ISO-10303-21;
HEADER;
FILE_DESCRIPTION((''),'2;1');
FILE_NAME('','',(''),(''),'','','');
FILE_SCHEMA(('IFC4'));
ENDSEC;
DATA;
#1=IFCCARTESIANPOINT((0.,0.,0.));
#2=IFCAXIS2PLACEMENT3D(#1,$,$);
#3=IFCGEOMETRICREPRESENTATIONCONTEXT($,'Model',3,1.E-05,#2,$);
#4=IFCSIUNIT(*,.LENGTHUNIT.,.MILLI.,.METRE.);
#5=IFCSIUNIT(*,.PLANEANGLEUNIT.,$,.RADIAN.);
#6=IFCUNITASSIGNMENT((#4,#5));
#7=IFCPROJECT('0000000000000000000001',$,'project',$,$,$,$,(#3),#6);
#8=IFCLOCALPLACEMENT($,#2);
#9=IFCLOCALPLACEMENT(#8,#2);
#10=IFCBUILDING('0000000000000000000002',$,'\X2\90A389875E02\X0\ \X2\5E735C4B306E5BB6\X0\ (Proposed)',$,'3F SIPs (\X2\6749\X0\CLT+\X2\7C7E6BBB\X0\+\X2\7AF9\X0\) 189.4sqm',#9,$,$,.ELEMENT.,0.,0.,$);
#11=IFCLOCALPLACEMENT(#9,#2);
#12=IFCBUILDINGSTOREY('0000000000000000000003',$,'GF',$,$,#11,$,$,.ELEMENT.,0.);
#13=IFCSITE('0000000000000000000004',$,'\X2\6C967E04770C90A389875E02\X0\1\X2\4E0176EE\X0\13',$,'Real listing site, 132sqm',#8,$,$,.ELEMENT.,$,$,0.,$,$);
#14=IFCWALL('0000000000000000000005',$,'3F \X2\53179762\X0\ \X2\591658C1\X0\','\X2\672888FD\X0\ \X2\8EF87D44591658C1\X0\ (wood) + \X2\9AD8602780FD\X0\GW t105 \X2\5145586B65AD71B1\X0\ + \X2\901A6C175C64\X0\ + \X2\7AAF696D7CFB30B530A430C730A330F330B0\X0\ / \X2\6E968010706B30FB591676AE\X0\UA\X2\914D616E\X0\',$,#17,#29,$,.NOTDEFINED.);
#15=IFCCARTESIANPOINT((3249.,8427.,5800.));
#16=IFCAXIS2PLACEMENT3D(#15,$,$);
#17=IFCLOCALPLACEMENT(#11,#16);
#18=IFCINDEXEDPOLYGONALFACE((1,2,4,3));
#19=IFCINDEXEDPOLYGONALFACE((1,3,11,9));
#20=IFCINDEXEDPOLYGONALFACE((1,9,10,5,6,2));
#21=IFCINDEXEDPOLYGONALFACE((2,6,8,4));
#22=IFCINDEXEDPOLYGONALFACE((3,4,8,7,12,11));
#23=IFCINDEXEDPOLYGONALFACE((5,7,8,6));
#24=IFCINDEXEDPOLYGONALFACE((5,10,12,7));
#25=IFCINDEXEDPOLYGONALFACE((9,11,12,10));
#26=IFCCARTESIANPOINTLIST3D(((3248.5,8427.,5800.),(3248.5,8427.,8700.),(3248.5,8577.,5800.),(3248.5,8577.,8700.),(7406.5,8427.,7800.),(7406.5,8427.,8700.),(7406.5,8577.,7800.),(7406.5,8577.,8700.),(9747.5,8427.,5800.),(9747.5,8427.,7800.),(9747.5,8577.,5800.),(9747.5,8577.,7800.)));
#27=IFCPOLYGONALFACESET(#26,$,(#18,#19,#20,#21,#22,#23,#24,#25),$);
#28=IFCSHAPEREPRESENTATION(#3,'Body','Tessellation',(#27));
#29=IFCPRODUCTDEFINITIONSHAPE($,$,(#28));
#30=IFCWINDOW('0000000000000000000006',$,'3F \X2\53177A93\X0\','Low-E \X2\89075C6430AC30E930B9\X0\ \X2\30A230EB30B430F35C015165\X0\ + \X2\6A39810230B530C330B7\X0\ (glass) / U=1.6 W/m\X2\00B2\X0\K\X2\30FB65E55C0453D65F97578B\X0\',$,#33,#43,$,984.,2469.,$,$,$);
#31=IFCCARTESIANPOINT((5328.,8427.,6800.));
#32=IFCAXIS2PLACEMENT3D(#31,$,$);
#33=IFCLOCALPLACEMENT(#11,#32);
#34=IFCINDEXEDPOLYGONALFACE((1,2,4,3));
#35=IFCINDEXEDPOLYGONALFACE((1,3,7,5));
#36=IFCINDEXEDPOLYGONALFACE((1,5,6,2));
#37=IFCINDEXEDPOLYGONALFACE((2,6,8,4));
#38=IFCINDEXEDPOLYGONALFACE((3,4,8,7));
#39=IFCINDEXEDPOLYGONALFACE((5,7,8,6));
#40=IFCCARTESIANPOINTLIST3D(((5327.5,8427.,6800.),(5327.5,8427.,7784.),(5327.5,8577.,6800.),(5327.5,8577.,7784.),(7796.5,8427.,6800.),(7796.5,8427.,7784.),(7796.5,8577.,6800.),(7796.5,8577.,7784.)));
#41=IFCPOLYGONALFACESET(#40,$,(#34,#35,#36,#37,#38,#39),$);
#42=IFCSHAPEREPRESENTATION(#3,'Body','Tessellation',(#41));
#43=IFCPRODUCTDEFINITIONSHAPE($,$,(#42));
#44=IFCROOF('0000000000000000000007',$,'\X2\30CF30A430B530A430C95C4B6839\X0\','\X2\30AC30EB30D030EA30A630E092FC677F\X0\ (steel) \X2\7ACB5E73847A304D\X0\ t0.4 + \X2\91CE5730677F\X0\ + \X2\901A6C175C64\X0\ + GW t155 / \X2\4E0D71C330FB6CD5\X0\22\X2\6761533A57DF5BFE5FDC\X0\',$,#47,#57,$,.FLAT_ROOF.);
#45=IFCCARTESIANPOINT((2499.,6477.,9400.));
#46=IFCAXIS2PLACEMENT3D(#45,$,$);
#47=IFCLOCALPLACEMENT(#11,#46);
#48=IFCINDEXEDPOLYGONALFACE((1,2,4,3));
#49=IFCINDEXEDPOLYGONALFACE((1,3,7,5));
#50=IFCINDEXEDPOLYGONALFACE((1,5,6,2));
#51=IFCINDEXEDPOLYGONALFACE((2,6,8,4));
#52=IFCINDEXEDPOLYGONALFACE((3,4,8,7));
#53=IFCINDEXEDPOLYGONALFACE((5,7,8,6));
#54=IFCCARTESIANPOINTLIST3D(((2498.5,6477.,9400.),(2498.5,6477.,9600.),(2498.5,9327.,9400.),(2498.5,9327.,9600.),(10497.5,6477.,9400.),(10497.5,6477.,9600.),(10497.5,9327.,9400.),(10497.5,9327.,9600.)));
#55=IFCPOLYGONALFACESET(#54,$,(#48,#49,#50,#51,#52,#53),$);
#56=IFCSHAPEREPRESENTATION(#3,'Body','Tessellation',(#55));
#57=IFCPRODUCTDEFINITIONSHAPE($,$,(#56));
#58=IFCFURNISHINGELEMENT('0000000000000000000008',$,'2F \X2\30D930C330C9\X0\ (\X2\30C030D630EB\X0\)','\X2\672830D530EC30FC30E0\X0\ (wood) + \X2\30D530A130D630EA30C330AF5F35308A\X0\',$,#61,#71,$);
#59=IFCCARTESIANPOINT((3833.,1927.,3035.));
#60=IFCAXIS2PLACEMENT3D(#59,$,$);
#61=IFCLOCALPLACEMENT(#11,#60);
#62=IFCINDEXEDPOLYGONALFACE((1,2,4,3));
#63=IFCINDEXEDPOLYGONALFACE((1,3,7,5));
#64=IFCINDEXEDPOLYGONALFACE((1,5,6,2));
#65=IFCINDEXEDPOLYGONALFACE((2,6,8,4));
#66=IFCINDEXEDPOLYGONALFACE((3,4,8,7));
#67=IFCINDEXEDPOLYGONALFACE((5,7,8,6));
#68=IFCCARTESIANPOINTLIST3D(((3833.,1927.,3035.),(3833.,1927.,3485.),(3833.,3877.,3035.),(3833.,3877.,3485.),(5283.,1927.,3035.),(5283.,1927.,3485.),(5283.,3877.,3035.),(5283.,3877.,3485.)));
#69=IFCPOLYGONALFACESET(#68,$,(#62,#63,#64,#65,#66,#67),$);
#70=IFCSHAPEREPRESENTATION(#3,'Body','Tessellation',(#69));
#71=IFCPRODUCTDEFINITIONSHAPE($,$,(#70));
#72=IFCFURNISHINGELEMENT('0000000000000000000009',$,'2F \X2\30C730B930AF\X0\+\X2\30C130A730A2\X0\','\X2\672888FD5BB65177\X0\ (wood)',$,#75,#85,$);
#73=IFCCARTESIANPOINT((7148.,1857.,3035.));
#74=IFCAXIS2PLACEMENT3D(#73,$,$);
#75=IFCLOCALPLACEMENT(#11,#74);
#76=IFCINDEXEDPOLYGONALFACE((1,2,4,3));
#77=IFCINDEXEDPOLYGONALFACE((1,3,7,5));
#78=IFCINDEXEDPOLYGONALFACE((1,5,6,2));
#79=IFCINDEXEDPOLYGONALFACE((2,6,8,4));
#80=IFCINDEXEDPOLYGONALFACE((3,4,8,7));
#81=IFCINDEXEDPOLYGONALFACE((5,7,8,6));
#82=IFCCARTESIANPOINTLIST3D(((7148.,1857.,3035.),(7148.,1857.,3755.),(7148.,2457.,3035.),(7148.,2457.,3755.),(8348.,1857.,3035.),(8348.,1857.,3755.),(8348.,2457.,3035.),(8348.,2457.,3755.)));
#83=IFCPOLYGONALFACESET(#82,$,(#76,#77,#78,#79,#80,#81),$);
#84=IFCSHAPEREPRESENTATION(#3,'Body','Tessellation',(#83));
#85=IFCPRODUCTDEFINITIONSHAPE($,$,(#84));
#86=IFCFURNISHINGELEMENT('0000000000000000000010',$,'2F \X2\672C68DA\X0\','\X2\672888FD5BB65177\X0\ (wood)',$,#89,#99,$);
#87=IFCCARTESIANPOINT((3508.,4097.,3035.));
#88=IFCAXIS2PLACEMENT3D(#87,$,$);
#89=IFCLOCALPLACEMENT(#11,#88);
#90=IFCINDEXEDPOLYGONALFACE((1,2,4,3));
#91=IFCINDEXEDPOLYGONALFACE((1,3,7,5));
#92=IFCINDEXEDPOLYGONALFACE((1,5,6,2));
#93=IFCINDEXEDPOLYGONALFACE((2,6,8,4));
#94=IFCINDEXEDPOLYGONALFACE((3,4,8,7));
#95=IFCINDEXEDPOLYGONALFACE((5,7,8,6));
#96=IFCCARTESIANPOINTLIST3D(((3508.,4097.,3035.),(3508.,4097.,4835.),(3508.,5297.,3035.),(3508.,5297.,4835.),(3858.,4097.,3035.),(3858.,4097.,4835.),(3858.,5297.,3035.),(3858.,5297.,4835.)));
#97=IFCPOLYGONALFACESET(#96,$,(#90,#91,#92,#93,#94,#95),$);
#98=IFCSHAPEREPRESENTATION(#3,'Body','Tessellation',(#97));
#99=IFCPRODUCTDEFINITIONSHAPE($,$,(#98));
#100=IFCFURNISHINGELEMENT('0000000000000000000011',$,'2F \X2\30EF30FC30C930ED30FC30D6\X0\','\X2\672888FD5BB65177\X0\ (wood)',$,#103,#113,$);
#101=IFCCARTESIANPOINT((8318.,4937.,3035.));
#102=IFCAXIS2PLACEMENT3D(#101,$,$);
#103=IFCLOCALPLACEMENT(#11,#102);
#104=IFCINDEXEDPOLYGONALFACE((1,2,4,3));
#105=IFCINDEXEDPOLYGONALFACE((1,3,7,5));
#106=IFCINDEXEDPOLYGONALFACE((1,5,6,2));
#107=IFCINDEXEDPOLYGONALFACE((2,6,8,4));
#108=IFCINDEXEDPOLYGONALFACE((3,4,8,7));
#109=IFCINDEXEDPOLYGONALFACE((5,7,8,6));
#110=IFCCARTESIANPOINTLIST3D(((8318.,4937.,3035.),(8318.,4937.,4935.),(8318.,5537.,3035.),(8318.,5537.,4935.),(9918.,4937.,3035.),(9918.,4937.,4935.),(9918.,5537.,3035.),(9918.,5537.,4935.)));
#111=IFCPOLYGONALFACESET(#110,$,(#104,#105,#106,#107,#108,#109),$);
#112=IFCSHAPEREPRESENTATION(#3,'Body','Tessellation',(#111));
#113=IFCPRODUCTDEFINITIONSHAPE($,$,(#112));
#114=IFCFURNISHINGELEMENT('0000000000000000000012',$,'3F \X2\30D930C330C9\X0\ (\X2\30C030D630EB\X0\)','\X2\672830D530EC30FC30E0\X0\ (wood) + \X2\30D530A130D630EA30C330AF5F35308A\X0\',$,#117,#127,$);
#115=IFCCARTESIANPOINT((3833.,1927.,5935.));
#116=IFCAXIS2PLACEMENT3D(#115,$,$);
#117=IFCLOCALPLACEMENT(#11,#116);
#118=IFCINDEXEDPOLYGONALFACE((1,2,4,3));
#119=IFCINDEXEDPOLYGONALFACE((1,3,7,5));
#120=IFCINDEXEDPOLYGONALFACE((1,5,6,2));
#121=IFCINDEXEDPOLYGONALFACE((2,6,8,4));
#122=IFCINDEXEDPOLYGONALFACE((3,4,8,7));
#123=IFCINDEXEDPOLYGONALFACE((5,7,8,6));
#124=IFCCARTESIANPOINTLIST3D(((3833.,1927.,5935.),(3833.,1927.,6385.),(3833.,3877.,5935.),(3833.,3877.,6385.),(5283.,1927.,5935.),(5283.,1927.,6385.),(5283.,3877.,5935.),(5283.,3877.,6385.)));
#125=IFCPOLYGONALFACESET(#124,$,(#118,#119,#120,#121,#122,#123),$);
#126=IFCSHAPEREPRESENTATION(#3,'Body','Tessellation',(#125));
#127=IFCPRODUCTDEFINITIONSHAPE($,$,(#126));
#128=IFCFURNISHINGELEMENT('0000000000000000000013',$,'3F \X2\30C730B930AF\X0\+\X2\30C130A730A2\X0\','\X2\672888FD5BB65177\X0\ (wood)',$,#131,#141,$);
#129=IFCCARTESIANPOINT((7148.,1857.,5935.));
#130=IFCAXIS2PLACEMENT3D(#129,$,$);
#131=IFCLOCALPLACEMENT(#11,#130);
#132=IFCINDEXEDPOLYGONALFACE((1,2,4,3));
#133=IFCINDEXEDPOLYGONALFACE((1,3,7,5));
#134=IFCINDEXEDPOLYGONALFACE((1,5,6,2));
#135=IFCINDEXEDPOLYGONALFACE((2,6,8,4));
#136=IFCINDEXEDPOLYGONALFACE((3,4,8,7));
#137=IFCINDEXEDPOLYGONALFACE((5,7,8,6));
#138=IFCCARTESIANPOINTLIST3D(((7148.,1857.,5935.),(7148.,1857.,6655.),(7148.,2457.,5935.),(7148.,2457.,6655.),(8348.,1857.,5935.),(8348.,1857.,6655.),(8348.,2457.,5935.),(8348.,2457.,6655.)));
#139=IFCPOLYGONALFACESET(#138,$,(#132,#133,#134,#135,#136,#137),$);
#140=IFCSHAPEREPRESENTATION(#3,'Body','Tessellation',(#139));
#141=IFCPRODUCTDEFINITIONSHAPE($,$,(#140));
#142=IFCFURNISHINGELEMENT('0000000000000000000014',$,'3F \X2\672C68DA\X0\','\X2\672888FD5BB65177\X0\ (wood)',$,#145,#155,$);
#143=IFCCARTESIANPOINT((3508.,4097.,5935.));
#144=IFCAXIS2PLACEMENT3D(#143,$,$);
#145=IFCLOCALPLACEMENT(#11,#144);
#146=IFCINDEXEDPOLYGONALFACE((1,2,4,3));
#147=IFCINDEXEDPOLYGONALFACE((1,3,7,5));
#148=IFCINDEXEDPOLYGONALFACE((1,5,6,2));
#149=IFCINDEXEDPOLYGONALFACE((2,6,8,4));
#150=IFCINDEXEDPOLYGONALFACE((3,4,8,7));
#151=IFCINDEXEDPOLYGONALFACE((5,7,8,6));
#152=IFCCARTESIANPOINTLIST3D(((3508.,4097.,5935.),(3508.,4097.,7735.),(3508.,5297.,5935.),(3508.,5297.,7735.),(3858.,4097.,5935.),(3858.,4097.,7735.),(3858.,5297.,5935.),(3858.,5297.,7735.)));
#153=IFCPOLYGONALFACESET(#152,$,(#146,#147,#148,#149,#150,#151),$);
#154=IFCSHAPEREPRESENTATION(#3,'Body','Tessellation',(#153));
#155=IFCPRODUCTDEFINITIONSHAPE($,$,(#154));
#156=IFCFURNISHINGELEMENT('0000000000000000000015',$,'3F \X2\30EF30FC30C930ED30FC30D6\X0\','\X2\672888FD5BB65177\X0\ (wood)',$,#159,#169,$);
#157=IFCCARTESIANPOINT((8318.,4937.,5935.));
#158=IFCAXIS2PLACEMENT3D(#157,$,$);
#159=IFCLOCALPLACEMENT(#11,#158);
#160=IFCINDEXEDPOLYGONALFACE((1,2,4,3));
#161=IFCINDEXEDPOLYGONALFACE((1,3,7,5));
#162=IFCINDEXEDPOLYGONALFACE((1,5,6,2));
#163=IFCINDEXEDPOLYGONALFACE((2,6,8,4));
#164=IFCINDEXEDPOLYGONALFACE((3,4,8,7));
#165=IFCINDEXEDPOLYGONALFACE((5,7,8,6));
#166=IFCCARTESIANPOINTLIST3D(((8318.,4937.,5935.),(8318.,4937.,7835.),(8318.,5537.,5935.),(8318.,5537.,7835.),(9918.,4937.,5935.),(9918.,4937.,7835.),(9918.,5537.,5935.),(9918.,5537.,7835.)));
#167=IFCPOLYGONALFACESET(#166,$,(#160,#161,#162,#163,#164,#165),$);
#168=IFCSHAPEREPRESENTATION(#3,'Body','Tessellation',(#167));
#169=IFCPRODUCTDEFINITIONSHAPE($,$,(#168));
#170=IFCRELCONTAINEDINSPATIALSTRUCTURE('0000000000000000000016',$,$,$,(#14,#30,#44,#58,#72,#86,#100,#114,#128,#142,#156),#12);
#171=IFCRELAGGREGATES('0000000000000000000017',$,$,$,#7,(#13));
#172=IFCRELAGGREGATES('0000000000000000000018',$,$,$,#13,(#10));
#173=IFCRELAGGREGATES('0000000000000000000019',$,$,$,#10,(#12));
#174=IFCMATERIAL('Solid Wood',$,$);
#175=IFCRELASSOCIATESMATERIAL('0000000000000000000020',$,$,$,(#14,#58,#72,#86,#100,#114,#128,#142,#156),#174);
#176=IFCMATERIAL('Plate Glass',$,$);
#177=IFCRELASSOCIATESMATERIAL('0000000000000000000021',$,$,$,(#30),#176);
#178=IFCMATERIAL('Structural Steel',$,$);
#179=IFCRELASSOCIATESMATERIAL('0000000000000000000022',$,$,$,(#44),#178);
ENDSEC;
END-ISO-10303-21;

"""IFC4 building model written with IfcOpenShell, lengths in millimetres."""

from ifc_helpers import new_model, si_unit, frame, frame_2d, origin, place, context, project, spatial, rectangle, extrude, material, element, fill, save


model = new_model("IFC4")

# Units and contexts
model_context = context("Model", 3, precision=1e-05, world=origin())
ifc_project = project(units=[si_unit("LENGTHUNIT", "METRE", prefix="MILLI"), si_unit("PLANEANGLEUNIT", "RADIAN")], contexts=[model_context])

# Site, building, storey
site_placement = place(None, origin())
site = spatial("IfcSite", under=ifc_project, at=site_placement, Name="沖縄県那覇市1丁目13", ObjectType="Real listing site, 132sqm", CompositionType="ELEMENT", RefElevation=0.0)
building_placement = place(site_placement, origin())
building = spatial("IfcBuilding", under=site, at=building_placement, Name="那覇市 平屋の家 (Proposed)", ObjectType="3F SIPs (杉CLT+籾殻+竹) 189.4sqm", CompositionType="ELEMENT", ElevationOfRefHeight=0.0, ElevationOfTerrain=0.0)
storey_placement = place(building_placement, origin())
storey = spatial("IfcBuildingStorey", under=building, at=storey_placement, Name="GF", CompositionType="ELEMENT", Elevation=0.0)

# Shared definitions
ifc_material_1 = material(Name="Solid Wood")

# Wall, opening, window
wall_1_placement = place(storey_placement, frame((3249.0, 8427.0, 5800.0)))
wall_1 = element("IfcWall", 1, at=wall_1_placement, inside=storey, material=ifc_material_1, Name="3F 北面 外壁", Description="木製 軸組外壁 (wood) + 高性能GW t105 充填断熱 + 通気層 + 窯業系サイディング / 準耐火・外皮UA配慮", PredefinedType="NOTDEFINED", context=model_context, shape_type="SweptSolid", body=[
    extrude(rectangle(XDim=6499.0, YDim=150.0, at=frame_2d((3249.0, 75.0))), frame((3249.0, 8427.0, 5800.0)), (0.0, 0.0, 1.0), 2900.0),
])
opening_1_placement = place(storey_placement, frame((5328.0, 8427.0, 6800.0)))
opening_1 = element("IfcOpeningElement", 2, at=opening_1_placement, cuts=wall_1, PredefinedType="NOTDEFINED", context=model_context, shape_type="SweptSolid", body=[
    extrude(rectangle(XDim=2469.0, YDim=150.0, at=frame_2d((1234.0, 75.0))), frame((5328.0, 8427.0, 6800.0)), (0.0, 0.0, 1.0), 984.0),
])
ifc_material_2 = material(Name="Plate Glass")
window_1_placement = place(storey_placement, frame((5328.0, 8427.0, 6800.0)))
window_1 = element("IfcWindow", 3, at=window_1_placement, inside=storey, material=ifc_material_2, Name="3F 北窓", Description="Low-E 複層ガラス アルゴン封入 + 樹脂サッシ (glass) / U=1.6 W/m²K・日射取得型", OverallHeight=984.0, OverallWidth=2469.0, context=model_context, shape_type="SweptSolid", body=[
    extrude(rectangle(XDim=2469.0, YDim=150.0, at=frame_2d((1234.0, 75.0))), frame((5328.0, 8427.0, 6800.0)), (0.0, 0.0, 1.0), 984.0),
])
fill(opening_1, window_1)

# Roof
ifc_material_3 = material(Name="Structural Steel")
roof_placement = place(storey_placement, frame((2499.0, 6477.0, 9400.0)))
element("IfcRoof", 4, at=roof_placement, inside=storey, material=ifc_material_3, Name="ハイサイド屋根", Description="ガルバリウム鋼板 (steel) 立平葺き t0.4 + 野地板 + 通気層 + GW t155 / 不燃・法22条区域対応", PredefinedType="FLAT_ROOF", context=model_context, shape_type="SweptSolid", body=[
    extrude(rectangle(XDim=7999.0, YDim=2850.0, at=frame_2d((3999.0, 1425.0))), frame((2499.0, 6477.0, 9400.0)), (0.0, 0.0, 1.0), 200.0),
])

# Furnishing elements
furnishing_1_placement = place(storey_placement, frame((3833.0, 1927.0, 3035.0)))
element("IfcFurnishingElement", 5, at=furnishing_1_placement, inside=storey, material=ifc_material_1, Name="2F ベッド (ダブル)", Description="木フレーム (wood) + ファブリック張り", context=model_context, shape_type="SweptSolid", body=[
    extrude(rectangle(XDim=1450.0, YDim=1950.0, at=frame_2d((725.0, 975.0))), frame((3833.0, 1927.0, 3035.0)), (0.0, 0.0, 1.0), 450.0),
])
furnishing_2_placement = place(storey_placement, frame((7148.0, 1857.0, 3035.0)))
element("IfcFurnishingElement", 6, at=furnishing_2_placement, inside=storey, material=ifc_material_1, Name="2F デスク+チェア", Description="木製家具 (wood)", context=model_context, shape_type="SweptSolid", body=[
    extrude(rectangle(XDim=1200.0, YDim=600.0, at=frame_2d((600.0, 300.0))), frame((7148.0, 1857.0, 3035.0)), (0.0, 0.0, 1.0), 720.0),
])
furnishing_3_placement = place(storey_placement, frame((3508.0, 4097.0, 3035.0)))
element("IfcFurnishingElement", 7, at=furnishing_3_placement, inside=storey, material=ifc_material_1, Name="2F 本棚", Description="木製家具 (wood)", context=model_context, shape_type="SweptSolid", body=[
    extrude(rectangle(XDim=350.0, YDim=1200.0, at=frame_2d((175.0, 600.0))), frame((3508.0, 4097.0, 3035.0)), (0.0, 0.0, 1.0), 1800.0),
])
furnishing_4_placement = place(storey_placement, frame((8318.0, 4937.0, 3035.0)))
element("IfcFurnishingElement", 8, at=furnishing_4_placement, inside=storey, material=ifc_material_1, Name="2F ワードローブ", Description="木製家具 (wood)", context=model_context, shape_type="SweptSolid", body=[
    extrude(rectangle(XDim=1600.0, YDim=600.0, at=frame_2d((800.0, 300.0))), frame((8318.0, 4937.0, 3035.0)), (0.0, 0.0, 1.0), 1900.0),
])
furnishing_5_placement = place(storey_placement, frame((3833.0, 1927.0, 5935.0)))
element("IfcFurnishingElement", 9, at=furnishing_5_placement, inside=storey, material=ifc_material_1, Name="3F ベッド (ダブル)", Description="木フレーム (wood) + ファブリック張り", context=model_context, shape_type="SweptSolid", body=[
    extrude(rectangle(XDim=1450.0, YDim=1950.0, at=frame_2d((725.0, 975.0))), frame((3833.0, 1927.0, 5935.0)), (0.0, 0.0, 1.0), 450.0),
])
furnishing_6_placement = place(storey_placement, frame((7148.0, 1857.0, 5935.0)))
element("IfcFurnishingElement", 10, at=furnishing_6_placement, inside=storey, material=ifc_material_1, Name="3F デスク+チェア", Description="木製家具 (wood)", context=model_context, shape_type="SweptSolid", body=[
    extrude(rectangle(XDim=1200.0, YDim=600.0, at=frame_2d((600.0, 300.0))), frame((7148.0, 1857.0, 5935.0)), (0.0, 0.0, 1.0), 720.0),
])
furnishing_7_placement = place(storey_placement, frame((3508.0, 4097.0, 5935.0)))
element("IfcFurnishingElement", 11, at=furnishing_7_placement, inside=storey, material=ifc_material_1, Name="3F 本棚", Description="木製家具 (wood)", context=model_context, shape_type="SweptSolid", body=[
    extrude(rectangle(XDim=350.0, YDim=1200.0, at=frame_2d((175.0, 600.0))), frame((3508.0, 4097.0, 5935.0)), (0.0, 0.0, 1.0), 1800.0),
])
furnishing_8_placement = place(storey_placement, frame((8318.0, 4937.0, 5935.0)))
element("IfcFurnishingElement", 12, at=furnishing_8_placement, inside=storey, material=ifc_material_1, Name="3F ワードローブ", Description="木製家具 (wood)", context=model_context, shape_type="SweptSolid", body=[
    extrude(rectangle(XDim=1600.0, YDim=600.0, at=frame_2d((800.0, 300.0))), frame((8318.0, 4937.0, 5935.0)), (0.0, 0.0, 1.0), 1900.0),
])

save(model, "model.ifc")
